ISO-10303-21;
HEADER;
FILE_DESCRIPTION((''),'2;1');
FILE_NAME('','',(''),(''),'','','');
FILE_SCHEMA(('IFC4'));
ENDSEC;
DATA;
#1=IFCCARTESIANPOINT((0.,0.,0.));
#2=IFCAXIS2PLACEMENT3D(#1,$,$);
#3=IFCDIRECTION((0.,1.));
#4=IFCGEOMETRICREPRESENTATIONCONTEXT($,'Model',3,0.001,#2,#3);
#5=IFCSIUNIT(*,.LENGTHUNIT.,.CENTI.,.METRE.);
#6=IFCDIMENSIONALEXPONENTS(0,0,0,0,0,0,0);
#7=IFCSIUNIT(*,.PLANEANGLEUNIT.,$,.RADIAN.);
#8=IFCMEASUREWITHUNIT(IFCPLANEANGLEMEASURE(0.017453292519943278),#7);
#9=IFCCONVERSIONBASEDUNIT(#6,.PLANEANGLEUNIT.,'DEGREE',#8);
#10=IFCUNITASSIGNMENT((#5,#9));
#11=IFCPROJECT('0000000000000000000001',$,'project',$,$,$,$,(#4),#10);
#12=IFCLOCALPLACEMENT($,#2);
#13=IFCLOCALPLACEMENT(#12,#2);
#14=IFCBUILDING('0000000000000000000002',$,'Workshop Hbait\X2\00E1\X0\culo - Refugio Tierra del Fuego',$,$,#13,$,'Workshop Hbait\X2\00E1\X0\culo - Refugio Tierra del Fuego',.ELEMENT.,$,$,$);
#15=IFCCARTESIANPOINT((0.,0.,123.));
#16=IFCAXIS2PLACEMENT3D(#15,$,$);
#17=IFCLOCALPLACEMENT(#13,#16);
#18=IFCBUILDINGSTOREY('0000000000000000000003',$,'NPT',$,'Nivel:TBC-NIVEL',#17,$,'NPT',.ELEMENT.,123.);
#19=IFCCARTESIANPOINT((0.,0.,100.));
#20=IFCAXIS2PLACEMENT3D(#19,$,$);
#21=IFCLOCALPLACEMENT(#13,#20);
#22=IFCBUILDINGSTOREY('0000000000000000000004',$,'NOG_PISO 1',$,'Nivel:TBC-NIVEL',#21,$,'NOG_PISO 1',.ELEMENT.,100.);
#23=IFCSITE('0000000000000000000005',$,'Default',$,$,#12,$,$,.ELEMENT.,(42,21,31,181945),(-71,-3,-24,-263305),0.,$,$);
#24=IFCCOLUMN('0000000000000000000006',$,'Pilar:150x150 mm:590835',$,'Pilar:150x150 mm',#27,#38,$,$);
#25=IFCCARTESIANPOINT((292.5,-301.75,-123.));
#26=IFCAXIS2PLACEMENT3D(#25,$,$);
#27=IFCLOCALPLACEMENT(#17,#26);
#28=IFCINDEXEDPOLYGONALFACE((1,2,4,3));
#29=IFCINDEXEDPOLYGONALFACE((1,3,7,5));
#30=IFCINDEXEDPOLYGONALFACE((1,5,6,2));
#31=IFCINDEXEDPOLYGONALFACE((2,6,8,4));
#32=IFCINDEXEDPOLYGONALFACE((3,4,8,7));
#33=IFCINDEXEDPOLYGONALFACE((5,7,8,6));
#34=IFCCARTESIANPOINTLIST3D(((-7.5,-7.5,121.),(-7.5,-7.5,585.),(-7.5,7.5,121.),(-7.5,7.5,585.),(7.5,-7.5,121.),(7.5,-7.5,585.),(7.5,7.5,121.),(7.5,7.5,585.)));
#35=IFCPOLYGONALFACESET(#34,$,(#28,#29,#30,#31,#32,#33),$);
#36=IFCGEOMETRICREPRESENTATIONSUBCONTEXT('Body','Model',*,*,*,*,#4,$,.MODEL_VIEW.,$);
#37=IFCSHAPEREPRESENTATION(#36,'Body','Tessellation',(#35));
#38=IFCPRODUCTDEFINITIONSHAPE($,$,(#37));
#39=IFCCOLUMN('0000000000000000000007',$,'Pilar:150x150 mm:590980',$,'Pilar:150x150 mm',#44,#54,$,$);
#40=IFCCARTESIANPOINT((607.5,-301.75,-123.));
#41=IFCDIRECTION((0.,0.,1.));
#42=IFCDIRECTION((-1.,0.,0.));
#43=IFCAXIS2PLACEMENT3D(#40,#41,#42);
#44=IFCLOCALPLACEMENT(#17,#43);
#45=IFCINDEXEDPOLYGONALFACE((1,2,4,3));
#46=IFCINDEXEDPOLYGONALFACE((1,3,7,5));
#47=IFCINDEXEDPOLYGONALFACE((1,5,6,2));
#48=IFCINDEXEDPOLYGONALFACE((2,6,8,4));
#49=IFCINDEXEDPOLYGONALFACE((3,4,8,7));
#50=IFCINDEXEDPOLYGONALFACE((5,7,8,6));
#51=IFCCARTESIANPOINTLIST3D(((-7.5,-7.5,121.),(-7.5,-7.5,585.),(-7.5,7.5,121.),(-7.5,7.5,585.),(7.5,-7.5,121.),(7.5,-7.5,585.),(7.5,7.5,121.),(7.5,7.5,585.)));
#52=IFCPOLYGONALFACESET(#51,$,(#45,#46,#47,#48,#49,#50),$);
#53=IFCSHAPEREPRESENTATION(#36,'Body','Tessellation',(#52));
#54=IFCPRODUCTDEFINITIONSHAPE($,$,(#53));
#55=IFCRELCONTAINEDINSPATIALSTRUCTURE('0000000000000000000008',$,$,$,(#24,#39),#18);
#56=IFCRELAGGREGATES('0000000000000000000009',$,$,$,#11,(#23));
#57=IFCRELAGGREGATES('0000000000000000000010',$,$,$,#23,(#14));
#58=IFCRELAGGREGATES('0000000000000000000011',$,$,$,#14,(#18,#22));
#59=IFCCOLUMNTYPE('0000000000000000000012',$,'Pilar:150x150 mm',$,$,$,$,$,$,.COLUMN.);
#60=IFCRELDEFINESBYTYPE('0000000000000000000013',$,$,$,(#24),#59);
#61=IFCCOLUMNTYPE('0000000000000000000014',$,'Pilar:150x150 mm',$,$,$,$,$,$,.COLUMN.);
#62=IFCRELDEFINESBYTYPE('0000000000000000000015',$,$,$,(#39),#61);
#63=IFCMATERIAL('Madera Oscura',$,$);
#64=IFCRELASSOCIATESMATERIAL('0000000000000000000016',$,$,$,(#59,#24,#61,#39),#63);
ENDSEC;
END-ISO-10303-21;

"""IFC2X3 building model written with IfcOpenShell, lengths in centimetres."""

from ifc_helpers import new_model, entity, si_unit, converted_unit, direction, frame, origin, origin_2d_with_axis, place, context, subcontext, project, spatial, rectangle, extrude, source, transform, mapped, material, type_object, type_shapes, element, save


model = new_model("IFC2X3")

# Units and contexts
model_context = context("Model", 3, precision=0.001, world=origin(), true_north=direction((0.0, 1.0)))
body_context = subcontext(model_context, "Body", "Model", "MODEL_VIEW")
ifc_project = project(units=[si_unit("LENGTHUNIT", "METRE", prefix="CENTI"), converted_unit("PLANEANGLEUNIT", "DEGREE", entity("IfcPlaneAngleMeasure", 0.017453292519943278), si_unit("PLANEANGLEUNIT", "RADIAN"), dimensions=[0, 0, 0, 0, 0, 0, 0])], contexts=[model_context])

# Site, building, storey
site_placement = place(None, origin())
site = spatial("IfcSite", under=ifc_project, at=site_placement, Name="Default", CompositionType="ELEMENT", RefLatitude=(42, 21, 31, 181945), RefLongitude=(-71, -3, -24, -263305), RefElevation=0.0)
building_placement = place(site_placement, origin())
building = spatial("IfcBuilding", under=site, at=building_placement, Name="Workshop Hbaitáculo - Refugio Tierra del Fuego", LongName="Workshop Hbaitáculo - Refugio Tierra del Fuego", CompositionType="ELEMENT")
storey_1_placement = place(building_placement, frame((0.0, 0.0, 123.0)))
storey_1 = spatial("IfcBuildingStorey", under=building, at=storey_1_placement, Name="NPT", ObjectType="Nivel:TBC-NIVEL", LongName="NPT", CompositionType="ELEMENT", Elevation=123.0)

# Columns
ifc_material_1 = material(Name="Madera Oscura")
column_type_1 = type_object("IfcColumnType", Name="Pilar:150x150 mm", PredefinedType="COLUMN", material=ifc_material_1)
shared_shape_1 = source(origin(), body_context, "Body", "SweptSolid", [
    extrude(rectangle(XDim=15.0, YDim=15.0, at=origin_2d_with_axis()), frame((0.0, 0.0, 121.0), z_axis=(0.0, 0.0, 1.0), x_axis=(0.0, 1.0, 0.0)), (0.0, 0.0, 1.0), 464.0),
])
type_shapes(column_type_1, [shared_shape_1])
column_1_placement = place(storey_1_placement, frame((292.5, -301.75, -123.0)))
element("IfcColumn", 1, at=column_1_placement, inside=storey_1, type_object=column_type_1, material=ifc_material_1, Name="Pilar:150x150 mm:590835", ObjectType="Pilar:150x150 mm", context=body_context, shape_type="MappedRepresentation", body=[
    mapped(shared_shape_1, transform((0.0, 0.0, 0.0), scale=1.0)),
])
column_type_2 = type_object("IfcColumnType", Name="Pilar:150x150 mm", PredefinedType="COLUMN", material=ifc_material_1)
shared_shape_2 = source(origin(), body_context, "Body", "SweptSolid", [
    extrude(rectangle(XDim=15.0, YDim=15.0, at=origin_2d_with_axis()), frame((0.0, 0.0, 121.0), z_axis=(0.0, 0.0, 1.0), x_axis=(-1.0, 0.0, 0.0)), (0.0, 0.0, 1.0), 464.0),
])
type_shapes(column_type_2, [shared_shape_2])
column_2_placement = place(storey_1_placement, frame((607.5, -301.75, -123.0), z_axis=(0.0, 0.0, 1.0), x_axis=(-1.0, 0.0, 0.0)))
element("IfcColumn", 2, at=column_2_placement, inside=storey_1, type_object=column_type_2, material=ifc_material_1, Name="Pilar:150x150 mm:590980", ObjectType="Pilar:150x150 mm", context=body_context, shape_type="MappedRepresentation", body=[
    mapped(shared_shape_2, transform((0.0, 0.0, 0.0), scale=1.0)),
])

# Shared definitions
storey_2_placement = place(building_placement, frame((0.0, 0.0, 100.0)))
storey_2 = spatial("IfcBuildingStorey", under=building, at=storey_2_placement, Name="NOG_PISO 1", ObjectType="Nivel:TBC-NIVEL", LongName="NOG_PISO 1", CompositionType="ELEMENT", Elevation=100.0)

save(model, "model.ifc")
